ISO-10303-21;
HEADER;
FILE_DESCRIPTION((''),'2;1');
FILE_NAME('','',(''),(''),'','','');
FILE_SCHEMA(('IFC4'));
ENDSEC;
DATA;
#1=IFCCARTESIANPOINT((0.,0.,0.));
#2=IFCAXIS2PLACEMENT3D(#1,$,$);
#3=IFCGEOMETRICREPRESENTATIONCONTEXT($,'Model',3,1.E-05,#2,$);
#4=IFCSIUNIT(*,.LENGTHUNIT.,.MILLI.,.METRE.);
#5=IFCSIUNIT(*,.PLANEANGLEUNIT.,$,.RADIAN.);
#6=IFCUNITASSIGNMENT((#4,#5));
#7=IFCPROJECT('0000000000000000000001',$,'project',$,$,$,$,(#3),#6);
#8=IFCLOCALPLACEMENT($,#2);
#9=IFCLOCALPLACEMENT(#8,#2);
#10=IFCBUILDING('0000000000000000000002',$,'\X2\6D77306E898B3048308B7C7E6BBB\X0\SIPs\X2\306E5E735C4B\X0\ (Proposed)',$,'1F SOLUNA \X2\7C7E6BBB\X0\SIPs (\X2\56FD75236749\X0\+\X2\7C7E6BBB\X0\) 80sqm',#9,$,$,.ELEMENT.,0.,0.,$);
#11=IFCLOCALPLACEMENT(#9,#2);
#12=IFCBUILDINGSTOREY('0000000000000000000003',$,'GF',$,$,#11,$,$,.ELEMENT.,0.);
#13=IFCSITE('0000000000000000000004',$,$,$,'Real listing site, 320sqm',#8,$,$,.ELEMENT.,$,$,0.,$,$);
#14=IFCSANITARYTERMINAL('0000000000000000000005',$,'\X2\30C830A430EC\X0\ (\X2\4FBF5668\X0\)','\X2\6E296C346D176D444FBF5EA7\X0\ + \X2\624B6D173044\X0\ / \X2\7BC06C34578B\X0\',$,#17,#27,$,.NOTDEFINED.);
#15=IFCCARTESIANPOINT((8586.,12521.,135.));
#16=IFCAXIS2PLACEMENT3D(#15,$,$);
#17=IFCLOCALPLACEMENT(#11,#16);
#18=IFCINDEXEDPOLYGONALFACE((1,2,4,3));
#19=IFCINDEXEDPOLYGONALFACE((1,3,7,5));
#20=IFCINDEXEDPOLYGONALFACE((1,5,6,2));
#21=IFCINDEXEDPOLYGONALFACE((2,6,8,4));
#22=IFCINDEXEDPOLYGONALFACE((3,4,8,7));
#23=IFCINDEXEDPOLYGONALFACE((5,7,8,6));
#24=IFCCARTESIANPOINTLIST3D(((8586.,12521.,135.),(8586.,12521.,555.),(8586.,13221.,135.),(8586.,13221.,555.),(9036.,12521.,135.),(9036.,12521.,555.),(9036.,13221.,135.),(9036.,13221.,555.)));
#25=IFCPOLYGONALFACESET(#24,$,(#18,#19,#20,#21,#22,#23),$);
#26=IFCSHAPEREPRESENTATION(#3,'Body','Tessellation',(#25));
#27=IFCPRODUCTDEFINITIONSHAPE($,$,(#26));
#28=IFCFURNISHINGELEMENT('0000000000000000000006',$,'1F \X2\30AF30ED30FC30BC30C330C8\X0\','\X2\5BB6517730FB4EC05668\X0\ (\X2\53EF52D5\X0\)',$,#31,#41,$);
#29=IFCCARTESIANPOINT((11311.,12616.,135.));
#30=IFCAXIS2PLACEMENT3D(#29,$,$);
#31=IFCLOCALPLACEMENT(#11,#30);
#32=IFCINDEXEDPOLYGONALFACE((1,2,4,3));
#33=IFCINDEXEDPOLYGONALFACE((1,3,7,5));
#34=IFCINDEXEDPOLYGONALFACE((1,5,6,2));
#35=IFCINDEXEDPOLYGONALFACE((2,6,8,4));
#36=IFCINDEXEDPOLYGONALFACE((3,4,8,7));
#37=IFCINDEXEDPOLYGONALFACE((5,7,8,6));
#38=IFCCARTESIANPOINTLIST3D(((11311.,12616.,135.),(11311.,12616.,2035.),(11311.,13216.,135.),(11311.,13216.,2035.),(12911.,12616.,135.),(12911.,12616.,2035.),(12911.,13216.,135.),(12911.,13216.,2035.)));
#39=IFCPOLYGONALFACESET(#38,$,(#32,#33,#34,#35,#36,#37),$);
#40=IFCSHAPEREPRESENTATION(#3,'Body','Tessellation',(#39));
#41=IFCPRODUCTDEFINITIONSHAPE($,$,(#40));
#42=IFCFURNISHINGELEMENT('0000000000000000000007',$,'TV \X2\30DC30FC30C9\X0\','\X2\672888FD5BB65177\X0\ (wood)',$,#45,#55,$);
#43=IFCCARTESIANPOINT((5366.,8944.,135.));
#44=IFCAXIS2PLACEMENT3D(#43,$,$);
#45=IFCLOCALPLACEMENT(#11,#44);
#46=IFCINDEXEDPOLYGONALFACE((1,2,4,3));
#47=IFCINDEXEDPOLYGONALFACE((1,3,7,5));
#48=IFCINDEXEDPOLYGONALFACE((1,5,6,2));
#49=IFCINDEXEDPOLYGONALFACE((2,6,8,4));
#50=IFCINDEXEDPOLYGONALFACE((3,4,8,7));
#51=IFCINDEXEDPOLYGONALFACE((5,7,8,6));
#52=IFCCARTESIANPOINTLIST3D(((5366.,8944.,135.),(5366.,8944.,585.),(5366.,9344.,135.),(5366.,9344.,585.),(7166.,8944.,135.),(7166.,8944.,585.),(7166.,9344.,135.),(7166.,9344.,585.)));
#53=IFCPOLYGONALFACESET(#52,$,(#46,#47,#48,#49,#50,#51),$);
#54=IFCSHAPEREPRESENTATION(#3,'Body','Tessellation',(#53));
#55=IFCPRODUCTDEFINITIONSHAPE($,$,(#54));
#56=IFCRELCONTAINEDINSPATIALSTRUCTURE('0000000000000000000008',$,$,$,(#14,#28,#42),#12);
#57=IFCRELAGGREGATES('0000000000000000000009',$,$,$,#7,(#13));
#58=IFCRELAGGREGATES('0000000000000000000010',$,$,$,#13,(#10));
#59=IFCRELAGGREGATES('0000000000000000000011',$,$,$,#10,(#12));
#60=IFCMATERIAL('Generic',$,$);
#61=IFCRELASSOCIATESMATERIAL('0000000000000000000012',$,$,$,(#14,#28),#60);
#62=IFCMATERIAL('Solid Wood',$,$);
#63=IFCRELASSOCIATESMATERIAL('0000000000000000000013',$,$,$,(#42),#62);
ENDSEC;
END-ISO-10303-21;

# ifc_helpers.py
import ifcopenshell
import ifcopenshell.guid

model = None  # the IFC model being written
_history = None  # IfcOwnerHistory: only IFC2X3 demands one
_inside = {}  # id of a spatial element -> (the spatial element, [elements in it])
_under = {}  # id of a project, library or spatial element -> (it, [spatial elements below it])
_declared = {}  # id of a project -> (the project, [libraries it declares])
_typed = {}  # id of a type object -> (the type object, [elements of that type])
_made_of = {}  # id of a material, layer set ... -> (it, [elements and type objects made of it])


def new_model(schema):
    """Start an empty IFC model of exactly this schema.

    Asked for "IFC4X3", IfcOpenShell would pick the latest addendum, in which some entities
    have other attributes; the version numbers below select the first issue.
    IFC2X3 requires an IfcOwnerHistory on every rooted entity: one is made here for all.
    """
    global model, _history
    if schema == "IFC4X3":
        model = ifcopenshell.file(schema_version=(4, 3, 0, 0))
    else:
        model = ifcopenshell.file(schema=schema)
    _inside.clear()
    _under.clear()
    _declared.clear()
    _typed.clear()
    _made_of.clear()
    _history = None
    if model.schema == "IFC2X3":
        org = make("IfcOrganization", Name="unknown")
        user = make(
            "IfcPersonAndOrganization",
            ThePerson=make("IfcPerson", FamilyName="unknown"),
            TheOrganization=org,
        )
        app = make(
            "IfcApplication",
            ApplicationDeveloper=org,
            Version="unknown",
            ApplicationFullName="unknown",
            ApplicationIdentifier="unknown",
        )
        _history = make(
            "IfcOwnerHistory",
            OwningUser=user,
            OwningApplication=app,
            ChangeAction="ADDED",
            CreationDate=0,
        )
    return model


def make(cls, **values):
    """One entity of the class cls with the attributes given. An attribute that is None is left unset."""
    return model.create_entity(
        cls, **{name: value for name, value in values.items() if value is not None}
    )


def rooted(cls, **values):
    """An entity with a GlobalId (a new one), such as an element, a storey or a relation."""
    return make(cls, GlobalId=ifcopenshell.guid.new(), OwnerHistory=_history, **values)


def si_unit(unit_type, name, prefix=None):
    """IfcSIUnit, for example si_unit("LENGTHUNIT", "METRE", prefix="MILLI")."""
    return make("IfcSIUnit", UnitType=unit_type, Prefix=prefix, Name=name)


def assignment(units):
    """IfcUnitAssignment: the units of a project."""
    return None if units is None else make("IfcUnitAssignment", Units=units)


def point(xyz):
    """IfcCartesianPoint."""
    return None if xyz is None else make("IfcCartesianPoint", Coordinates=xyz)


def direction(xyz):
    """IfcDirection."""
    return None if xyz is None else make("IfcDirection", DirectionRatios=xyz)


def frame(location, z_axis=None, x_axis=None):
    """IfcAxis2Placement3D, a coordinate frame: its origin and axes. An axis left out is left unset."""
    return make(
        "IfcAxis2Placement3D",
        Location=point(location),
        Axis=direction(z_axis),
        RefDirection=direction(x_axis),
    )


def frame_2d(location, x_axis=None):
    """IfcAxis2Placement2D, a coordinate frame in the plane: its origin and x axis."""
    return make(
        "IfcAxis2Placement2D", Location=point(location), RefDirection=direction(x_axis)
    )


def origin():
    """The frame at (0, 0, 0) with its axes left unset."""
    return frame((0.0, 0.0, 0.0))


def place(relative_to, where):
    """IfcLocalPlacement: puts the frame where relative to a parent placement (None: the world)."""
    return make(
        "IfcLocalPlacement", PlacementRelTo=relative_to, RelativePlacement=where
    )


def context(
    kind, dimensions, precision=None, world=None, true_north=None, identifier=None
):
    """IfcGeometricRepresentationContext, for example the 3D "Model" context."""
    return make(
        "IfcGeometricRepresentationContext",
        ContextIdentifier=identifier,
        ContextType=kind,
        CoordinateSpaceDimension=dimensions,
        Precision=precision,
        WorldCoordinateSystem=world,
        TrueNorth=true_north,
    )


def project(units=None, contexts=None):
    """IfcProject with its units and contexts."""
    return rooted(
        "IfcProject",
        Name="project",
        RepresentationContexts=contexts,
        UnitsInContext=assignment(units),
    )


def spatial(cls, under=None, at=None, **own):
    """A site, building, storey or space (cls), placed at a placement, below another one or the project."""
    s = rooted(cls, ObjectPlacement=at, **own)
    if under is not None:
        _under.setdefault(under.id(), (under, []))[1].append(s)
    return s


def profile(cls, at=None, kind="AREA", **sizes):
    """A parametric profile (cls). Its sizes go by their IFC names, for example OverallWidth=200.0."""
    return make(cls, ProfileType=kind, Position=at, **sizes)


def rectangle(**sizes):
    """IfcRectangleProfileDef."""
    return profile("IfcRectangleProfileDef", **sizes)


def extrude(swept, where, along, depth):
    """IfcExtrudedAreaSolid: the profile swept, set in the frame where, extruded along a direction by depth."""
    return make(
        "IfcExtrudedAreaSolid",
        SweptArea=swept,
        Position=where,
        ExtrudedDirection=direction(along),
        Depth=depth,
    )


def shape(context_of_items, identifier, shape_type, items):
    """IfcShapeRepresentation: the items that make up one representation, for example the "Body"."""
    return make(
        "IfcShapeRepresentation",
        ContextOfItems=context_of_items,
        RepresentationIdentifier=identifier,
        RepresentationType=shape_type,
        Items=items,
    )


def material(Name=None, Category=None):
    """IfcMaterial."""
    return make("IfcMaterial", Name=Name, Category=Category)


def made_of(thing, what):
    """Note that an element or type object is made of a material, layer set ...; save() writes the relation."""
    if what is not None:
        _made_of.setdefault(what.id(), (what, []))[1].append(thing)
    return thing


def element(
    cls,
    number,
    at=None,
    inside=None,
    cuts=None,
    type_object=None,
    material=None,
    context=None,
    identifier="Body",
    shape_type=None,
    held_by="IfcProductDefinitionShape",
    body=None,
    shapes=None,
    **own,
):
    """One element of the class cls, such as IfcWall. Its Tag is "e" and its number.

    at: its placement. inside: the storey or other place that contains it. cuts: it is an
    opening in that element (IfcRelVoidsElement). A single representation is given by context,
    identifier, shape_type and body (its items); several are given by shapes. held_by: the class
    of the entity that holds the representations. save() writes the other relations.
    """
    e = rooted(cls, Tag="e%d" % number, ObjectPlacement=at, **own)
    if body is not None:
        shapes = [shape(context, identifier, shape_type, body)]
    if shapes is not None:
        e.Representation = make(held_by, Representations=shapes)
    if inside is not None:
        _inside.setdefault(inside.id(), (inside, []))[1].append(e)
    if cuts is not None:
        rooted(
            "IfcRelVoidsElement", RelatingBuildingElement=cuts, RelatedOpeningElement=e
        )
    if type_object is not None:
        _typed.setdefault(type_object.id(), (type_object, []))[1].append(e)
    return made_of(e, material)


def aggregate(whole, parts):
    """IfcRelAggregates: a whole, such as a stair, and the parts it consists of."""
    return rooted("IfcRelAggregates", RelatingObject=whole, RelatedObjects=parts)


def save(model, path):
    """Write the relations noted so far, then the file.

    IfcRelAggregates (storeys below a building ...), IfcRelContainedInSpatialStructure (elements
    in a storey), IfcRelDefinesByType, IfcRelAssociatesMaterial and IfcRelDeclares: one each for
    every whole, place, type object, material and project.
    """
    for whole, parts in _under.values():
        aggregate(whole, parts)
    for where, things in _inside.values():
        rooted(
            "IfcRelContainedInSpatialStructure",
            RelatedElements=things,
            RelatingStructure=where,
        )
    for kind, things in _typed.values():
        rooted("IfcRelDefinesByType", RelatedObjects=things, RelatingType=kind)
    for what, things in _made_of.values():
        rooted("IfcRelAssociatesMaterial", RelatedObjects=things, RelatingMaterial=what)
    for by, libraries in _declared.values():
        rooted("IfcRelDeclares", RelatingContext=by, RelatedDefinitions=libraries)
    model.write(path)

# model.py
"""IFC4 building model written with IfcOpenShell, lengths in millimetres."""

from ifc_helpers import new_model, si_unit, frame, frame_2d, origin, place, context, project, spatial, rectangle, extrude, material, element, save


model = new_model("IFC4")

# Units and contexts
model_context = context("Model", 3, precision=1e-05, world=origin())
ifc_project = project(units=[si_unit("LENGTHUNIT", "METRE", prefix="MILLI"), si_unit("PLANEANGLEUNIT", "RADIAN")], contexts=[model_context])

# Site, building, storey
site_placement = place(None, origin())
site = spatial("IfcSite", under=ifc_project, at=site_placement, ObjectType="Real listing site, 320sqm", CompositionType="ELEMENT", RefElevation=0.0)
building_placement = place(site_placement, origin())
building = spatial("IfcBuilding", under=site, at=building_placement, Name="海の見える籾殻SIPsの平屋 (Proposed)", ObjectType="1F SOLUNA 籾殻SIPs (国産杉+籾殻) 80sqm", CompositionType="ELEMENT", ElevationOfRefHeight=0.0, ElevationOfTerrain=0.0)
storey_placement = place(building_placement, origin())
storey = spatial("IfcBuildingStorey", under=building, at=storey_placement, Name="GF", CompositionType="ELEMENT", Elevation=0.0)

# Shared definitions
ifc_material_1 = material(Name="Solid Wood")

# Sanitary terminal
ifc_material_2 = material(Name="Generic")
sanitary_terminal_1_placement = place(storey_placement, frame((8586.0, 12521.0, 135.0)))
element("IfcSanitaryTerminal", 1, at=sanitary_terminal_1_placement, inside=storey, material=ifc_material_2, Name="トイレ (便器)", Description="温水洗浄便座 + 手洗い / 節水型", PredefinedType="NOTDEFINED", context=model_context, shape_type="SweptSolid", body=[
    extrude(rectangle(XDim=450.0, YDim=700.0, at=frame_2d((225.0, 350.0))), frame((8586.0, 12521.0, 135.0)), (0.0, 0.0, 1.0), 420.0),
])

# Furnishing elements
furnishing_1_placement = place(storey_placement, frame((11311.0, 12616.0, 135.0)))
element("IfcFurnishingElement", 2, at=furnishing_1_placement, inside=storey, material=ifc_material_2, Name="1F クローゼット", Description="家具・什器 (可動)", context=model_context, shape_type="SweptSolid", body=[
    extrude(rectangle(XDim=1600.0, YDim=600.0, at=frame_2d((800.0, 300.0))), frame((11311.0, 12616.0, 135.0)), (0.0, 0.0, 1.0), 1900.0),
])
furnishing_2_placement = place(storey_placement, frame((5366.0, 8944.0, 135.0)))
element("IfcFurnishingElement", 3, at=furnishing_2_placement, inside=storey, material=ifc_material_1, Name="TV ボード", Description="木製家具 (wood)", context=model_context, shape_type="SweptSolid", body=[
    extrude(rectangle(XDim=1800.0, YDim=400.0, at=frame_2d((900.0, 200.0))), frame((5366.0, 8944.0, 135.0)), (0.0, 0.0, 1.0), 450.0),
])

save(model, "model.ifc")
